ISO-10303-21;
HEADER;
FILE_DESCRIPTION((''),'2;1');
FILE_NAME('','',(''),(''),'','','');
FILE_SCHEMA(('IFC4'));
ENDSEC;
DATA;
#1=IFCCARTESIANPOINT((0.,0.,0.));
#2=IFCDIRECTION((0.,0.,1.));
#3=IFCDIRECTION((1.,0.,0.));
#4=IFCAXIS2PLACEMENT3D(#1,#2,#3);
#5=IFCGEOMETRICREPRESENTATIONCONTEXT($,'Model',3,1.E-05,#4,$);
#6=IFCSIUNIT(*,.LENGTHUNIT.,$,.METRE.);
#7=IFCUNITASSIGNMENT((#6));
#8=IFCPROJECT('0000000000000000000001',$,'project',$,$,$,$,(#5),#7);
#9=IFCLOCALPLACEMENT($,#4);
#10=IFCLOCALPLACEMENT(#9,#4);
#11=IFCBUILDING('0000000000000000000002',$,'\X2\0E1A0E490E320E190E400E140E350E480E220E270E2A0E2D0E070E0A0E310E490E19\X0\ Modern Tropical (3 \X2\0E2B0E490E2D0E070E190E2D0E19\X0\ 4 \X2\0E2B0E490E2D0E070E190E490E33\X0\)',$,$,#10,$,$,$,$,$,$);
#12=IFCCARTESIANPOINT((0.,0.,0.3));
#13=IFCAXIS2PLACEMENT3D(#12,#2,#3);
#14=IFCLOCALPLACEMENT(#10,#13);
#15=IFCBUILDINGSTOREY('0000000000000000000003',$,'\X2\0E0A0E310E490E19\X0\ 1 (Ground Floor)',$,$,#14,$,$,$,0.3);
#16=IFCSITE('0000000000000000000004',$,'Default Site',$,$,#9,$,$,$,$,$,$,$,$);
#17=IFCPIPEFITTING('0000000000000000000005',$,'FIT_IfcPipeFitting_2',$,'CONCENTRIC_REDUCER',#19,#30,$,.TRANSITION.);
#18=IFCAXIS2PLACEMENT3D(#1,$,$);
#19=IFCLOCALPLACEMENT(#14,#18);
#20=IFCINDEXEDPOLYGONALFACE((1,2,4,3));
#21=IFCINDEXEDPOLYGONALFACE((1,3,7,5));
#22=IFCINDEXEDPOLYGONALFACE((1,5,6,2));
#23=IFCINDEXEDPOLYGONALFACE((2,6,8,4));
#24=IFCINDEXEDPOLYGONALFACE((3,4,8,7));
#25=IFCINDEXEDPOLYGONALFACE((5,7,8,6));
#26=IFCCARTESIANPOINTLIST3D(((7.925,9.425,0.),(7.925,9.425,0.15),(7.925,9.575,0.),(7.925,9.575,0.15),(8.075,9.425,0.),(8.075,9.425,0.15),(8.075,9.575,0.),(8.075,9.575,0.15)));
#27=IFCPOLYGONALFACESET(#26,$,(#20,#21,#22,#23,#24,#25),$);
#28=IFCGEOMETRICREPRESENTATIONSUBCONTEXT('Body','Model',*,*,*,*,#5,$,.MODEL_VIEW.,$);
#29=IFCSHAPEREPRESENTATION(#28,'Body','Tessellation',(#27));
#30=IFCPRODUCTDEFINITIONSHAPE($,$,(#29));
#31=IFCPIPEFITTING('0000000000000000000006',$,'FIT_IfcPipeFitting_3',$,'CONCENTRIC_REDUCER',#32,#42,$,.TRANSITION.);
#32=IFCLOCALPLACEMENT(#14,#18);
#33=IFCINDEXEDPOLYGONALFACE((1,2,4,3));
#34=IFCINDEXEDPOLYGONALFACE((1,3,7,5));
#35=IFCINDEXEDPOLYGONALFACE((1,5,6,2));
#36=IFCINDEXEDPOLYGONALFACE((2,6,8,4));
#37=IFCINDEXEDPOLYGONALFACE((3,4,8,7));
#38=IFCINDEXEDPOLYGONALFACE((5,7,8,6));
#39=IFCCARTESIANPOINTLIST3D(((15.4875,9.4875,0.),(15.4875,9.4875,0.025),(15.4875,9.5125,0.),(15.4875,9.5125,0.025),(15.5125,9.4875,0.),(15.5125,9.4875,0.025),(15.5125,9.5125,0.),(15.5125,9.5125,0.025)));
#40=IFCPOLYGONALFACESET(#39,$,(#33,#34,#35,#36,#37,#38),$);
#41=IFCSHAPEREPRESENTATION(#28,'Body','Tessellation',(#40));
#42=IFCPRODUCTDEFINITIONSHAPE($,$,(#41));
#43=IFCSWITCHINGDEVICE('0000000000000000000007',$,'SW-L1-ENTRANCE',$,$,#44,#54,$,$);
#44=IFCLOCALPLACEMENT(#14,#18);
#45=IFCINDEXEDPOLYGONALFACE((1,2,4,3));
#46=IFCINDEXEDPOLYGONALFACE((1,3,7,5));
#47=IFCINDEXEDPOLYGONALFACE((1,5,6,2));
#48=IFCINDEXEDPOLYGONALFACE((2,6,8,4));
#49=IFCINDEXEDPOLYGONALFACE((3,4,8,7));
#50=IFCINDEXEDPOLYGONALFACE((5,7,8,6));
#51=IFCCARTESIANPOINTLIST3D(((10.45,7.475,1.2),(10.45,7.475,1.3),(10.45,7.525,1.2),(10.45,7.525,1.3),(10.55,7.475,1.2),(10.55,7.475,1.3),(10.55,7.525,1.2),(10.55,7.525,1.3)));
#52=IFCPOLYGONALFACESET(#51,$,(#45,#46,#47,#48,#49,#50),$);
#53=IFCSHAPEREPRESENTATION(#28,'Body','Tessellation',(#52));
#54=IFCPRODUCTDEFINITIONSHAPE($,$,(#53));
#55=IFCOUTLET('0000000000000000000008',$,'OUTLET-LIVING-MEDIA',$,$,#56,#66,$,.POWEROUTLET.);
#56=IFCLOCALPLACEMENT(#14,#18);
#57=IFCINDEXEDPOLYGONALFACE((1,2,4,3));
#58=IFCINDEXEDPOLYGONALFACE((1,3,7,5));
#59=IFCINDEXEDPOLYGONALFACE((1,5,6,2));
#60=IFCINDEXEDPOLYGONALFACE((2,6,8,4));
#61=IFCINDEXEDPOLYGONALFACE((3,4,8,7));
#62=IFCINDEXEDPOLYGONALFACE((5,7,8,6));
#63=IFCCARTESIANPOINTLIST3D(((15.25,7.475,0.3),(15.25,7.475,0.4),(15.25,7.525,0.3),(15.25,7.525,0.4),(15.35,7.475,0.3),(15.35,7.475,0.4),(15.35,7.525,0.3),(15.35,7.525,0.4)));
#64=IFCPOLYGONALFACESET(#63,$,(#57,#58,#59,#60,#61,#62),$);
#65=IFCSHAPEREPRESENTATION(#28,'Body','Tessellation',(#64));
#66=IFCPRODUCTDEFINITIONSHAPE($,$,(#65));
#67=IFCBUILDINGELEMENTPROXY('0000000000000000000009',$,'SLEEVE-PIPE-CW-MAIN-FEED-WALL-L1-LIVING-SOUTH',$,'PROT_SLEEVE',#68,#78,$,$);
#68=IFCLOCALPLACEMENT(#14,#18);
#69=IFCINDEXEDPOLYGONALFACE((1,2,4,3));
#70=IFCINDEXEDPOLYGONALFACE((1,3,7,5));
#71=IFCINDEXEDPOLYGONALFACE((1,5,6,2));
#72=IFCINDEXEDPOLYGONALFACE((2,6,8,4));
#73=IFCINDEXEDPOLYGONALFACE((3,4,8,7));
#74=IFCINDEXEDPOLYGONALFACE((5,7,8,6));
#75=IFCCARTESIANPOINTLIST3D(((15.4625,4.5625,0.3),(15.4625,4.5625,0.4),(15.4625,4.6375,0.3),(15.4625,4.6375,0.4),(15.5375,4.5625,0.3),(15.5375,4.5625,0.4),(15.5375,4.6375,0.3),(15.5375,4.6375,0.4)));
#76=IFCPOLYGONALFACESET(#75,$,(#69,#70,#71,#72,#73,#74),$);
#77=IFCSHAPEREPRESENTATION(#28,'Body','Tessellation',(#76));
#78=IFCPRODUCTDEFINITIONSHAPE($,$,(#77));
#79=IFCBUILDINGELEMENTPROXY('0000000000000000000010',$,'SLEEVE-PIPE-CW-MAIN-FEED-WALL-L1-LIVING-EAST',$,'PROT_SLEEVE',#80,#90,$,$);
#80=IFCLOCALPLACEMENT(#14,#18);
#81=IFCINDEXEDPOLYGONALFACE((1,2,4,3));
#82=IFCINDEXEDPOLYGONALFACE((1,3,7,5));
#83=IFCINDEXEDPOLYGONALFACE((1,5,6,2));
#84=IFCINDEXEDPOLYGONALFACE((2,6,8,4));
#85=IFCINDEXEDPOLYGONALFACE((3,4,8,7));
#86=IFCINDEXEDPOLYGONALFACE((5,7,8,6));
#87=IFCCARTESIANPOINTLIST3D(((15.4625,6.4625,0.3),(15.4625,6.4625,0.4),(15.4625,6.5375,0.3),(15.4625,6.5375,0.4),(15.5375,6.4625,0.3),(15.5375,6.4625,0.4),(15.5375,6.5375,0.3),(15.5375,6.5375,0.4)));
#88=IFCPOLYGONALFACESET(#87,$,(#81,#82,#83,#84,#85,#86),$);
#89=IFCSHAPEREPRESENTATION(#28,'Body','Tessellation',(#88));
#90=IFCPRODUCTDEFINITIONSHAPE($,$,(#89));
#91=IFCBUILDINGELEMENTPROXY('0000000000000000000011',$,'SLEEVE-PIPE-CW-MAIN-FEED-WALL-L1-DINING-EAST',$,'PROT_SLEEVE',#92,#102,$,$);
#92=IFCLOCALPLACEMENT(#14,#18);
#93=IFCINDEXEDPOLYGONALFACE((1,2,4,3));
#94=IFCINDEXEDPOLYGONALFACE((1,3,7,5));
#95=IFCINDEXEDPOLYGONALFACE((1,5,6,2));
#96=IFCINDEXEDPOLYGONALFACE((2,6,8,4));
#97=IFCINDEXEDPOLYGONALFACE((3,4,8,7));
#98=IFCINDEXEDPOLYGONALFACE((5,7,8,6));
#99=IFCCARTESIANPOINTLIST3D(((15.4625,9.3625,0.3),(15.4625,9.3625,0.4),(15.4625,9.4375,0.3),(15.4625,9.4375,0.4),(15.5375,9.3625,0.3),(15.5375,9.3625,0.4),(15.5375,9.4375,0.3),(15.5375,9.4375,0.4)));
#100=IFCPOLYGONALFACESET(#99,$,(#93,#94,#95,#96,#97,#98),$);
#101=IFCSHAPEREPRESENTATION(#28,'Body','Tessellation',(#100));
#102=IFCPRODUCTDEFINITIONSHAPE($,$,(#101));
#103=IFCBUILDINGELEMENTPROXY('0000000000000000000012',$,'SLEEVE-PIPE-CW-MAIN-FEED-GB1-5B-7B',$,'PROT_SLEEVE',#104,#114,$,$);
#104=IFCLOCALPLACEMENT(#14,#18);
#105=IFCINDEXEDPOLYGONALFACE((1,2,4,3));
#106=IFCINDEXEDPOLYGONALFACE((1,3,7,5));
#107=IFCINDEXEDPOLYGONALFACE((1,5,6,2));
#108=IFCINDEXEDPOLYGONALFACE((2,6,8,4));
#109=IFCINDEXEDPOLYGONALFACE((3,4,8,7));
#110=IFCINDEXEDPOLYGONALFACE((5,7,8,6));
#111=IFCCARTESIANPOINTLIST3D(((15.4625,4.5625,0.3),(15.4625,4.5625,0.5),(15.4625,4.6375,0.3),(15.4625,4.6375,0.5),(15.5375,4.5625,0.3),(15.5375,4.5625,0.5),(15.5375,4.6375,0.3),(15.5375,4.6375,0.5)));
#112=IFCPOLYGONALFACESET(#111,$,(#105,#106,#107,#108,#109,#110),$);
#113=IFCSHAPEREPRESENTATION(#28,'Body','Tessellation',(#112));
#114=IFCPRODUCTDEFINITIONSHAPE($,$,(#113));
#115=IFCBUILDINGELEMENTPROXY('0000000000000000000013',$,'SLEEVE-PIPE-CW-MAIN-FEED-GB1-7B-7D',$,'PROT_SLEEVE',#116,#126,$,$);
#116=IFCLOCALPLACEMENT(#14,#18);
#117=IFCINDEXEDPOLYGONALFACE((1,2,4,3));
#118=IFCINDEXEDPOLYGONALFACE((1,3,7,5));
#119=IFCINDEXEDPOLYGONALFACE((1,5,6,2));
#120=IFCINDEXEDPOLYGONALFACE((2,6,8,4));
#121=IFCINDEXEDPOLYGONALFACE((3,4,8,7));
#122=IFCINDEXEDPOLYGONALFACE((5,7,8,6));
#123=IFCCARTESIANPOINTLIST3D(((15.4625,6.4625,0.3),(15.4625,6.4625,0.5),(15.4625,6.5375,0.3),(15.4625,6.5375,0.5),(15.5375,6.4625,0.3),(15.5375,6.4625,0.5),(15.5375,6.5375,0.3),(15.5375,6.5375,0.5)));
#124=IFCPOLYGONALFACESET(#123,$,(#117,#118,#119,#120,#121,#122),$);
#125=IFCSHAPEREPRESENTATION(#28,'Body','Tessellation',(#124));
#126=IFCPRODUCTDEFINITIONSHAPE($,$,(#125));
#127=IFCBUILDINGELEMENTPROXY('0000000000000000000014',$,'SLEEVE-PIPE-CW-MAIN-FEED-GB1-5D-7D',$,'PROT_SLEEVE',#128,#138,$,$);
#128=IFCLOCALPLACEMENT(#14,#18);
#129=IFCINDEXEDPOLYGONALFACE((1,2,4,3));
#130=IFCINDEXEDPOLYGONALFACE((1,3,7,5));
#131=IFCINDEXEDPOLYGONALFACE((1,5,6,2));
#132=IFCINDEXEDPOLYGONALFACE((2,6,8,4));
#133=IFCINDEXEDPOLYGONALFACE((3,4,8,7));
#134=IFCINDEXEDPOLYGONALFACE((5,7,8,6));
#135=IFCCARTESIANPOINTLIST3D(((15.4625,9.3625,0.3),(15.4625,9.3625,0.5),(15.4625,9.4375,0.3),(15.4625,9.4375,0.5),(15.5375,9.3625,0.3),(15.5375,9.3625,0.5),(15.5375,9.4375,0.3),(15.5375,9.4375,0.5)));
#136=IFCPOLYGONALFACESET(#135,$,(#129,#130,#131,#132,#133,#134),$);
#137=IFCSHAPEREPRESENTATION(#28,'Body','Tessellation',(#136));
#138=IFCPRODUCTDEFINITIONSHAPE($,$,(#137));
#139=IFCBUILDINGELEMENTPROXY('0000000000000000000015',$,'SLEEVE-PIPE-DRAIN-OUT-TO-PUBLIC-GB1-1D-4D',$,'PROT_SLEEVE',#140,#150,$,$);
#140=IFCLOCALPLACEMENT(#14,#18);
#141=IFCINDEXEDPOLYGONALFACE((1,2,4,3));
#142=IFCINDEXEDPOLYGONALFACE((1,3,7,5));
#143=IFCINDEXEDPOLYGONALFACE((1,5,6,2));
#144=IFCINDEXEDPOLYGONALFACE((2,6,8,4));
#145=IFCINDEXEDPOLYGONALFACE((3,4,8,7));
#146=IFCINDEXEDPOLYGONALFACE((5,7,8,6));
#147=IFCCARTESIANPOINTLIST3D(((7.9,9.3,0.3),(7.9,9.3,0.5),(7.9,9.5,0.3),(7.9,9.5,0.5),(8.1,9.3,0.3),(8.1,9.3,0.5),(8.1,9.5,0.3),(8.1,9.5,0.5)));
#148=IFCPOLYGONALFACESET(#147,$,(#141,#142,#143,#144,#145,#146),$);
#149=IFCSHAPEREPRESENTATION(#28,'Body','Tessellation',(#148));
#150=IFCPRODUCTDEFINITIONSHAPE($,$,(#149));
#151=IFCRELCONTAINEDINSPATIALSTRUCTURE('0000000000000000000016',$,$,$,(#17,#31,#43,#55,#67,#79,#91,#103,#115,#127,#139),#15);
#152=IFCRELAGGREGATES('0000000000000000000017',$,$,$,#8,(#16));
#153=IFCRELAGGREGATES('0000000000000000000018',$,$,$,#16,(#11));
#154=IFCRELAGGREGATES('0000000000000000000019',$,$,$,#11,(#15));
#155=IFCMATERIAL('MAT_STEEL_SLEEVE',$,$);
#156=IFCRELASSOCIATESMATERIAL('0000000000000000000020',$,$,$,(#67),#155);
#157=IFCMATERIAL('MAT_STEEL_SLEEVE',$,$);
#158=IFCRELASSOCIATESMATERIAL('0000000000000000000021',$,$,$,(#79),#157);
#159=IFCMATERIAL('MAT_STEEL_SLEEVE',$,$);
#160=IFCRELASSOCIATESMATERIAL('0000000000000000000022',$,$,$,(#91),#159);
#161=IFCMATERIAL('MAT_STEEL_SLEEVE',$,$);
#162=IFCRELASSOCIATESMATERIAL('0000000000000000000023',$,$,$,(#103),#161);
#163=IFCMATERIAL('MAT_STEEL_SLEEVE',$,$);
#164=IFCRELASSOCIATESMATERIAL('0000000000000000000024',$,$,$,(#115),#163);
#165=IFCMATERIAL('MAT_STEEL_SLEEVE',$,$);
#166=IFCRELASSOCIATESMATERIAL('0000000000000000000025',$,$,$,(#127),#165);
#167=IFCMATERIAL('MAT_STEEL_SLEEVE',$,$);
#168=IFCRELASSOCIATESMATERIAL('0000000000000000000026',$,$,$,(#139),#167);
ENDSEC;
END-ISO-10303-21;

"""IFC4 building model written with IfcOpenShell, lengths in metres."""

from ifc_helpers import new_model, si_unit, frame, origin_with_axes, origin_2d, place, context, subcontext, project, spatial, rectangle, extrude, material, element, save


model = new_model("IFC4")

# Units and contexts
model_context = context("Model", 3, precision=1e-05, world=origin_with_axes())
body_context = subcontext(model_context, "Body", "Model", "MODEL_VIEW")
ifc_project = project(units=[si_unit("LENGTHUNIT", "METRE")], contexts=[model_context])

# Site, building, storey
site_placement = place(None, origin_with_axes())
site = spatial("IfcSite", under=ifc_project, at=site_placement, Name="Default Site")
building_placement = place(site_placement, origin_with_axes())
building = spatial("IfcBuilding", under=site, at=building_placement, Name="บ้านเดี่ยวสองชั้น Modern Tropical (3 ห้องนอน 4 ห้องน้ำ)")
storey_placement = place(building_placement, frame((0.0, 0.0, 0.3), z_axis=(0.0, 0.0, 1.0), x_axis=(1.0, 0.0, 0.0)))
storey = spatial("IfcBuildingStorey", under=building, at=storey_placement, Name="ชั้น 1 (Ground Floor)", Elevation=0.3)

# Pipe fittings
pipe_fitting_1_placement = place(storey_placement, frame((8.0, 9.5, 0.0), z_axis=(0.0, 0.0, 1.0), x_axis=(1.0, 0.0, 0.0)))
element("IfcPipeFitting", 1, at=pipe_fitting_1_placement, inside=storey, Name="FIT_IfcPipeFitting_2", ObjectType="CONCENTRIC_REDUCER", PredefinedType="TRANSITION", context=body_context, shape_type="SweptSolid", body=[
    extrude(rectangle(XDim=0.15, YDim=0.15, at=origin_2d()), origin_with_axes(), (0.0, 0.0, 1.0), 0.15),
])
pipe_fitting_2_placement = place(storey_placement, frame((15.5, 9.5, 0.0), z_axis=(0.0, 0.0, 1.0), x_axis=(1.0, 0.0, 0.0)))
element("IfcPipeFitting", 2, at=pipe_fitting_2_placement, inside=storey, Name="FIT_IfcPipeFitting_3", ObjectType="CONCENTRIC_REDUCER", PredefinedType="TRANSITION", context=body_context, shape_type="SweptSolid", body=[
    extrude(rectangle(XDim=0.025, YDim=0.025, at=origin_2d()), origin_with_axes(), (0.0, 0.0, 1.0), 0.025),
])

# Switching device
switching_device_placement = place(storey_placement, frame((10.5, 7.5, 1.2), z_axis=(0.0, 0.0, 1.0), x_axis=(1.0, 0.0, 0.0)))
element("IfcSwitchingDevice", 3, at=switching_device_placement, inside=storey, Name="SW-L1-ENTRANCE", context=body_context, shape_type="SweptSolid", body=[
    extrude(rectangle(XDim=0.1, YDim=0.05, at=origin_2d()), origin_with_axes(), (0.0, 0.0, 1.0), 0.1),
])

# Outlet
outlet_placement = place(storey_placement, frame((15.3, 7.5, 0.3), z_axis=(0.0, 0.0, 1.0), x_axis=(1.0, 0.0, 0.0)))
element("IfcOutlet", 4, at=outlet_placement, inside=storey, Name="OUTLET-LIVING-MEDIA", PredefinedType="POWEROUTLET", context=body_context, shape_type="SweptSolid", body=[
    extrude(rectangle(XDim=0.1, YDim=0.05, at=origin_2d()), origin_with_axes(), (0.0, 0.0, 1.0), 0.1),
])

# Building element proxies
ifc_material_1 = material(Name="MAT_STEEL_SLEEVE")
proxy_1_placement = place(storey_placement, frame((15.5, 4.6, 0.3), z_axis=(0.0, 0.0, 1.0), x_axis=(1.0, 0.0, 0.0)))
element("IfcBuildingElementProxy", 5, at=proxy_1_placement, inside=storey, material=ifc_material_1, Name="SLEEVE-PIPE-CW-MAIN-FEED-WALL-L1-LIVING-SOUTH", ObjectType="PROT_SLEEVE", context=body_context, shape_type="SweptSolid", body=[
    extrude(rectangle(XDim=0.075, YDim=0.075, at=origin_2d()), origin_with_axes(), (0.0, 0.0, 1.0), 0.1),
])
ifc_material_2 = material(Name="MAT_STEEL_SLEEVE")
proxy_2_placement = place(storey_placement, frame((15.5, 6.5, 0.3), z_axis=(0.0, 0.0, 1.0), x_axis=(1.0, 0.0, 0.0)))
element("IfcBuildingElementProxy", 6, at=proxy_2_placement, inside=storey, material=ifc_material_2, Name="SLEEVE-PIPE-CW-MAIN-FEED-WALL-L1-LIVING-EAST", ObjectType="PROT_SLEEVE", context=body_context, shape_type="SweptSolid", body=[
    extrude(rectangle(XDim=0.075, YDim=0.075, at=origin_2d()), origin_with_axes(), (0.0, 0.0, 1.0), 0.1),
])
ifc_material_3 = material(Name="MAT_STEEL_SLEEVE")
proxy_3_placement = place(storey_placement, frame((15.5, 9.4, 0.3), z_axis=(0.0, 0.0, 1.0), x_axis=(1.0, 0.0, 0.0)))
element("IfcBuildingElementProxy", 7, at=proxy_3_placement, inside=storey, material=ifc_material_3, Name="SLEEVE-PIPE-CW-MAIN-FEED-WALL-L1-DINING-EAST", ObjectType="PROT_SLEEVE", context=body_context, shape_type="SweptSolid", body=[
    extrude(rectangle(XDim=0.075, YDim=0.075, at=origin_2d()), origin_with_axes(), (0.0, 0.0, 1.0), 0.1),
])
ifc_material_4 = material(Name="MAT_STEEL_SLEEVE")
proxy_4_placement = place(storey_placement, frame((15.5, 4.6, 0.3), z_axis=(0.0, 0.0, 1.0), x_axis=(1.0, 0.0, 0.0)))
element("IfcBuildingElementProxy", 8, at=proxy_4_placement, inside=storey, material=ifc_material_4, Name="SLEEVE-PIPE-CW-MAIN-FEED-GB1-5B-7B", ObjectType="PROT_SLEEVE", context=body_context, shape_type="SweptSolid", body=[
    extrude(rectangle(XDim=0.075, YDim=0.075, at=origin_2d()), origin_with_axes(), (0.0, 0.0, 1.0), 0.2),
])
ifc_material_5 = material(Name="MAT_STEEL_SLEEVE")
proxy_5_placement = place(storey_placement, frame((15.5, 6.5, 0.3), z_axis=(0.0, 0.0, 1.0), x_axis=(1.0, 0.0, 0.0)))
element("IfcBuildingElementProxy", 9, at=proxy_5_placement, inside=storey, material=ifc_material_5, Name="SLEEVE-PIPE-CW-MAIN-FEED-GB1-7B-7D", ObjectType="PROT_SLEEVE", context=body_context, shape_type="SweptSolid", body=[
    extrude(rectangle(XDim=0.075, YDim=0.075, at=origin_2d()), origin_with_axes(), (0.0, 0.0, 1.0), 0.2),
])
ifc_material_6 = material(Name="MAT_STEEL_SLEEVE")
proxy_6_placement = place(storey_placement, frame((15.5, 9.4, 0.3), z_axis=(0.0, 0.0, 1.0), x_axis=(1.0, 0.0, 0.0)))
element("IfcBuildingElementProxy", 10, at=proxy_6_placement, inside=storey, material=ifc_material_6, Name="SLEEVE-PIPE-CW-MAIN-FEED-GB1-5D-7D", ObjectType="PROT_SLEEVE", context=body_context, shape_type="SweptSolid", body=[
    extrude(rectangle(XDim=0.075, YDim=0.075, at=origin_2d()), origin_with_axes(), (0.0, 0.0, 1.0), 0.2),
])
ifc_material_7 = material(Name="MAT_STEEL_SLEEVE")
proxy_7_placement = place(storey_placement, frame((8.0, 9.4, 0.3), z_axis=(0.0, 0.0, 1.0), x_axis=(1.0, 0.0, 0.0)))
element("IfcBuildingElementProxy", 11, at=proxy_7_placement, inside=storey, material=ifc_material_7, Name="SLEEVE-PIPE-DRAIN-OUT-TO-PUBLIC-GB1-1D-4D", ObjectType="PROT_SLEEVE", context=body_context, shape_type="SweptSolid", body=[
    extrude(rectangle(XDim=0.2, YDim=0.2, at=origin_2d()), origin_with_axes(), (0.0, 0.0, 1.0), 0.2),
])

save(model, "model.ifc")
